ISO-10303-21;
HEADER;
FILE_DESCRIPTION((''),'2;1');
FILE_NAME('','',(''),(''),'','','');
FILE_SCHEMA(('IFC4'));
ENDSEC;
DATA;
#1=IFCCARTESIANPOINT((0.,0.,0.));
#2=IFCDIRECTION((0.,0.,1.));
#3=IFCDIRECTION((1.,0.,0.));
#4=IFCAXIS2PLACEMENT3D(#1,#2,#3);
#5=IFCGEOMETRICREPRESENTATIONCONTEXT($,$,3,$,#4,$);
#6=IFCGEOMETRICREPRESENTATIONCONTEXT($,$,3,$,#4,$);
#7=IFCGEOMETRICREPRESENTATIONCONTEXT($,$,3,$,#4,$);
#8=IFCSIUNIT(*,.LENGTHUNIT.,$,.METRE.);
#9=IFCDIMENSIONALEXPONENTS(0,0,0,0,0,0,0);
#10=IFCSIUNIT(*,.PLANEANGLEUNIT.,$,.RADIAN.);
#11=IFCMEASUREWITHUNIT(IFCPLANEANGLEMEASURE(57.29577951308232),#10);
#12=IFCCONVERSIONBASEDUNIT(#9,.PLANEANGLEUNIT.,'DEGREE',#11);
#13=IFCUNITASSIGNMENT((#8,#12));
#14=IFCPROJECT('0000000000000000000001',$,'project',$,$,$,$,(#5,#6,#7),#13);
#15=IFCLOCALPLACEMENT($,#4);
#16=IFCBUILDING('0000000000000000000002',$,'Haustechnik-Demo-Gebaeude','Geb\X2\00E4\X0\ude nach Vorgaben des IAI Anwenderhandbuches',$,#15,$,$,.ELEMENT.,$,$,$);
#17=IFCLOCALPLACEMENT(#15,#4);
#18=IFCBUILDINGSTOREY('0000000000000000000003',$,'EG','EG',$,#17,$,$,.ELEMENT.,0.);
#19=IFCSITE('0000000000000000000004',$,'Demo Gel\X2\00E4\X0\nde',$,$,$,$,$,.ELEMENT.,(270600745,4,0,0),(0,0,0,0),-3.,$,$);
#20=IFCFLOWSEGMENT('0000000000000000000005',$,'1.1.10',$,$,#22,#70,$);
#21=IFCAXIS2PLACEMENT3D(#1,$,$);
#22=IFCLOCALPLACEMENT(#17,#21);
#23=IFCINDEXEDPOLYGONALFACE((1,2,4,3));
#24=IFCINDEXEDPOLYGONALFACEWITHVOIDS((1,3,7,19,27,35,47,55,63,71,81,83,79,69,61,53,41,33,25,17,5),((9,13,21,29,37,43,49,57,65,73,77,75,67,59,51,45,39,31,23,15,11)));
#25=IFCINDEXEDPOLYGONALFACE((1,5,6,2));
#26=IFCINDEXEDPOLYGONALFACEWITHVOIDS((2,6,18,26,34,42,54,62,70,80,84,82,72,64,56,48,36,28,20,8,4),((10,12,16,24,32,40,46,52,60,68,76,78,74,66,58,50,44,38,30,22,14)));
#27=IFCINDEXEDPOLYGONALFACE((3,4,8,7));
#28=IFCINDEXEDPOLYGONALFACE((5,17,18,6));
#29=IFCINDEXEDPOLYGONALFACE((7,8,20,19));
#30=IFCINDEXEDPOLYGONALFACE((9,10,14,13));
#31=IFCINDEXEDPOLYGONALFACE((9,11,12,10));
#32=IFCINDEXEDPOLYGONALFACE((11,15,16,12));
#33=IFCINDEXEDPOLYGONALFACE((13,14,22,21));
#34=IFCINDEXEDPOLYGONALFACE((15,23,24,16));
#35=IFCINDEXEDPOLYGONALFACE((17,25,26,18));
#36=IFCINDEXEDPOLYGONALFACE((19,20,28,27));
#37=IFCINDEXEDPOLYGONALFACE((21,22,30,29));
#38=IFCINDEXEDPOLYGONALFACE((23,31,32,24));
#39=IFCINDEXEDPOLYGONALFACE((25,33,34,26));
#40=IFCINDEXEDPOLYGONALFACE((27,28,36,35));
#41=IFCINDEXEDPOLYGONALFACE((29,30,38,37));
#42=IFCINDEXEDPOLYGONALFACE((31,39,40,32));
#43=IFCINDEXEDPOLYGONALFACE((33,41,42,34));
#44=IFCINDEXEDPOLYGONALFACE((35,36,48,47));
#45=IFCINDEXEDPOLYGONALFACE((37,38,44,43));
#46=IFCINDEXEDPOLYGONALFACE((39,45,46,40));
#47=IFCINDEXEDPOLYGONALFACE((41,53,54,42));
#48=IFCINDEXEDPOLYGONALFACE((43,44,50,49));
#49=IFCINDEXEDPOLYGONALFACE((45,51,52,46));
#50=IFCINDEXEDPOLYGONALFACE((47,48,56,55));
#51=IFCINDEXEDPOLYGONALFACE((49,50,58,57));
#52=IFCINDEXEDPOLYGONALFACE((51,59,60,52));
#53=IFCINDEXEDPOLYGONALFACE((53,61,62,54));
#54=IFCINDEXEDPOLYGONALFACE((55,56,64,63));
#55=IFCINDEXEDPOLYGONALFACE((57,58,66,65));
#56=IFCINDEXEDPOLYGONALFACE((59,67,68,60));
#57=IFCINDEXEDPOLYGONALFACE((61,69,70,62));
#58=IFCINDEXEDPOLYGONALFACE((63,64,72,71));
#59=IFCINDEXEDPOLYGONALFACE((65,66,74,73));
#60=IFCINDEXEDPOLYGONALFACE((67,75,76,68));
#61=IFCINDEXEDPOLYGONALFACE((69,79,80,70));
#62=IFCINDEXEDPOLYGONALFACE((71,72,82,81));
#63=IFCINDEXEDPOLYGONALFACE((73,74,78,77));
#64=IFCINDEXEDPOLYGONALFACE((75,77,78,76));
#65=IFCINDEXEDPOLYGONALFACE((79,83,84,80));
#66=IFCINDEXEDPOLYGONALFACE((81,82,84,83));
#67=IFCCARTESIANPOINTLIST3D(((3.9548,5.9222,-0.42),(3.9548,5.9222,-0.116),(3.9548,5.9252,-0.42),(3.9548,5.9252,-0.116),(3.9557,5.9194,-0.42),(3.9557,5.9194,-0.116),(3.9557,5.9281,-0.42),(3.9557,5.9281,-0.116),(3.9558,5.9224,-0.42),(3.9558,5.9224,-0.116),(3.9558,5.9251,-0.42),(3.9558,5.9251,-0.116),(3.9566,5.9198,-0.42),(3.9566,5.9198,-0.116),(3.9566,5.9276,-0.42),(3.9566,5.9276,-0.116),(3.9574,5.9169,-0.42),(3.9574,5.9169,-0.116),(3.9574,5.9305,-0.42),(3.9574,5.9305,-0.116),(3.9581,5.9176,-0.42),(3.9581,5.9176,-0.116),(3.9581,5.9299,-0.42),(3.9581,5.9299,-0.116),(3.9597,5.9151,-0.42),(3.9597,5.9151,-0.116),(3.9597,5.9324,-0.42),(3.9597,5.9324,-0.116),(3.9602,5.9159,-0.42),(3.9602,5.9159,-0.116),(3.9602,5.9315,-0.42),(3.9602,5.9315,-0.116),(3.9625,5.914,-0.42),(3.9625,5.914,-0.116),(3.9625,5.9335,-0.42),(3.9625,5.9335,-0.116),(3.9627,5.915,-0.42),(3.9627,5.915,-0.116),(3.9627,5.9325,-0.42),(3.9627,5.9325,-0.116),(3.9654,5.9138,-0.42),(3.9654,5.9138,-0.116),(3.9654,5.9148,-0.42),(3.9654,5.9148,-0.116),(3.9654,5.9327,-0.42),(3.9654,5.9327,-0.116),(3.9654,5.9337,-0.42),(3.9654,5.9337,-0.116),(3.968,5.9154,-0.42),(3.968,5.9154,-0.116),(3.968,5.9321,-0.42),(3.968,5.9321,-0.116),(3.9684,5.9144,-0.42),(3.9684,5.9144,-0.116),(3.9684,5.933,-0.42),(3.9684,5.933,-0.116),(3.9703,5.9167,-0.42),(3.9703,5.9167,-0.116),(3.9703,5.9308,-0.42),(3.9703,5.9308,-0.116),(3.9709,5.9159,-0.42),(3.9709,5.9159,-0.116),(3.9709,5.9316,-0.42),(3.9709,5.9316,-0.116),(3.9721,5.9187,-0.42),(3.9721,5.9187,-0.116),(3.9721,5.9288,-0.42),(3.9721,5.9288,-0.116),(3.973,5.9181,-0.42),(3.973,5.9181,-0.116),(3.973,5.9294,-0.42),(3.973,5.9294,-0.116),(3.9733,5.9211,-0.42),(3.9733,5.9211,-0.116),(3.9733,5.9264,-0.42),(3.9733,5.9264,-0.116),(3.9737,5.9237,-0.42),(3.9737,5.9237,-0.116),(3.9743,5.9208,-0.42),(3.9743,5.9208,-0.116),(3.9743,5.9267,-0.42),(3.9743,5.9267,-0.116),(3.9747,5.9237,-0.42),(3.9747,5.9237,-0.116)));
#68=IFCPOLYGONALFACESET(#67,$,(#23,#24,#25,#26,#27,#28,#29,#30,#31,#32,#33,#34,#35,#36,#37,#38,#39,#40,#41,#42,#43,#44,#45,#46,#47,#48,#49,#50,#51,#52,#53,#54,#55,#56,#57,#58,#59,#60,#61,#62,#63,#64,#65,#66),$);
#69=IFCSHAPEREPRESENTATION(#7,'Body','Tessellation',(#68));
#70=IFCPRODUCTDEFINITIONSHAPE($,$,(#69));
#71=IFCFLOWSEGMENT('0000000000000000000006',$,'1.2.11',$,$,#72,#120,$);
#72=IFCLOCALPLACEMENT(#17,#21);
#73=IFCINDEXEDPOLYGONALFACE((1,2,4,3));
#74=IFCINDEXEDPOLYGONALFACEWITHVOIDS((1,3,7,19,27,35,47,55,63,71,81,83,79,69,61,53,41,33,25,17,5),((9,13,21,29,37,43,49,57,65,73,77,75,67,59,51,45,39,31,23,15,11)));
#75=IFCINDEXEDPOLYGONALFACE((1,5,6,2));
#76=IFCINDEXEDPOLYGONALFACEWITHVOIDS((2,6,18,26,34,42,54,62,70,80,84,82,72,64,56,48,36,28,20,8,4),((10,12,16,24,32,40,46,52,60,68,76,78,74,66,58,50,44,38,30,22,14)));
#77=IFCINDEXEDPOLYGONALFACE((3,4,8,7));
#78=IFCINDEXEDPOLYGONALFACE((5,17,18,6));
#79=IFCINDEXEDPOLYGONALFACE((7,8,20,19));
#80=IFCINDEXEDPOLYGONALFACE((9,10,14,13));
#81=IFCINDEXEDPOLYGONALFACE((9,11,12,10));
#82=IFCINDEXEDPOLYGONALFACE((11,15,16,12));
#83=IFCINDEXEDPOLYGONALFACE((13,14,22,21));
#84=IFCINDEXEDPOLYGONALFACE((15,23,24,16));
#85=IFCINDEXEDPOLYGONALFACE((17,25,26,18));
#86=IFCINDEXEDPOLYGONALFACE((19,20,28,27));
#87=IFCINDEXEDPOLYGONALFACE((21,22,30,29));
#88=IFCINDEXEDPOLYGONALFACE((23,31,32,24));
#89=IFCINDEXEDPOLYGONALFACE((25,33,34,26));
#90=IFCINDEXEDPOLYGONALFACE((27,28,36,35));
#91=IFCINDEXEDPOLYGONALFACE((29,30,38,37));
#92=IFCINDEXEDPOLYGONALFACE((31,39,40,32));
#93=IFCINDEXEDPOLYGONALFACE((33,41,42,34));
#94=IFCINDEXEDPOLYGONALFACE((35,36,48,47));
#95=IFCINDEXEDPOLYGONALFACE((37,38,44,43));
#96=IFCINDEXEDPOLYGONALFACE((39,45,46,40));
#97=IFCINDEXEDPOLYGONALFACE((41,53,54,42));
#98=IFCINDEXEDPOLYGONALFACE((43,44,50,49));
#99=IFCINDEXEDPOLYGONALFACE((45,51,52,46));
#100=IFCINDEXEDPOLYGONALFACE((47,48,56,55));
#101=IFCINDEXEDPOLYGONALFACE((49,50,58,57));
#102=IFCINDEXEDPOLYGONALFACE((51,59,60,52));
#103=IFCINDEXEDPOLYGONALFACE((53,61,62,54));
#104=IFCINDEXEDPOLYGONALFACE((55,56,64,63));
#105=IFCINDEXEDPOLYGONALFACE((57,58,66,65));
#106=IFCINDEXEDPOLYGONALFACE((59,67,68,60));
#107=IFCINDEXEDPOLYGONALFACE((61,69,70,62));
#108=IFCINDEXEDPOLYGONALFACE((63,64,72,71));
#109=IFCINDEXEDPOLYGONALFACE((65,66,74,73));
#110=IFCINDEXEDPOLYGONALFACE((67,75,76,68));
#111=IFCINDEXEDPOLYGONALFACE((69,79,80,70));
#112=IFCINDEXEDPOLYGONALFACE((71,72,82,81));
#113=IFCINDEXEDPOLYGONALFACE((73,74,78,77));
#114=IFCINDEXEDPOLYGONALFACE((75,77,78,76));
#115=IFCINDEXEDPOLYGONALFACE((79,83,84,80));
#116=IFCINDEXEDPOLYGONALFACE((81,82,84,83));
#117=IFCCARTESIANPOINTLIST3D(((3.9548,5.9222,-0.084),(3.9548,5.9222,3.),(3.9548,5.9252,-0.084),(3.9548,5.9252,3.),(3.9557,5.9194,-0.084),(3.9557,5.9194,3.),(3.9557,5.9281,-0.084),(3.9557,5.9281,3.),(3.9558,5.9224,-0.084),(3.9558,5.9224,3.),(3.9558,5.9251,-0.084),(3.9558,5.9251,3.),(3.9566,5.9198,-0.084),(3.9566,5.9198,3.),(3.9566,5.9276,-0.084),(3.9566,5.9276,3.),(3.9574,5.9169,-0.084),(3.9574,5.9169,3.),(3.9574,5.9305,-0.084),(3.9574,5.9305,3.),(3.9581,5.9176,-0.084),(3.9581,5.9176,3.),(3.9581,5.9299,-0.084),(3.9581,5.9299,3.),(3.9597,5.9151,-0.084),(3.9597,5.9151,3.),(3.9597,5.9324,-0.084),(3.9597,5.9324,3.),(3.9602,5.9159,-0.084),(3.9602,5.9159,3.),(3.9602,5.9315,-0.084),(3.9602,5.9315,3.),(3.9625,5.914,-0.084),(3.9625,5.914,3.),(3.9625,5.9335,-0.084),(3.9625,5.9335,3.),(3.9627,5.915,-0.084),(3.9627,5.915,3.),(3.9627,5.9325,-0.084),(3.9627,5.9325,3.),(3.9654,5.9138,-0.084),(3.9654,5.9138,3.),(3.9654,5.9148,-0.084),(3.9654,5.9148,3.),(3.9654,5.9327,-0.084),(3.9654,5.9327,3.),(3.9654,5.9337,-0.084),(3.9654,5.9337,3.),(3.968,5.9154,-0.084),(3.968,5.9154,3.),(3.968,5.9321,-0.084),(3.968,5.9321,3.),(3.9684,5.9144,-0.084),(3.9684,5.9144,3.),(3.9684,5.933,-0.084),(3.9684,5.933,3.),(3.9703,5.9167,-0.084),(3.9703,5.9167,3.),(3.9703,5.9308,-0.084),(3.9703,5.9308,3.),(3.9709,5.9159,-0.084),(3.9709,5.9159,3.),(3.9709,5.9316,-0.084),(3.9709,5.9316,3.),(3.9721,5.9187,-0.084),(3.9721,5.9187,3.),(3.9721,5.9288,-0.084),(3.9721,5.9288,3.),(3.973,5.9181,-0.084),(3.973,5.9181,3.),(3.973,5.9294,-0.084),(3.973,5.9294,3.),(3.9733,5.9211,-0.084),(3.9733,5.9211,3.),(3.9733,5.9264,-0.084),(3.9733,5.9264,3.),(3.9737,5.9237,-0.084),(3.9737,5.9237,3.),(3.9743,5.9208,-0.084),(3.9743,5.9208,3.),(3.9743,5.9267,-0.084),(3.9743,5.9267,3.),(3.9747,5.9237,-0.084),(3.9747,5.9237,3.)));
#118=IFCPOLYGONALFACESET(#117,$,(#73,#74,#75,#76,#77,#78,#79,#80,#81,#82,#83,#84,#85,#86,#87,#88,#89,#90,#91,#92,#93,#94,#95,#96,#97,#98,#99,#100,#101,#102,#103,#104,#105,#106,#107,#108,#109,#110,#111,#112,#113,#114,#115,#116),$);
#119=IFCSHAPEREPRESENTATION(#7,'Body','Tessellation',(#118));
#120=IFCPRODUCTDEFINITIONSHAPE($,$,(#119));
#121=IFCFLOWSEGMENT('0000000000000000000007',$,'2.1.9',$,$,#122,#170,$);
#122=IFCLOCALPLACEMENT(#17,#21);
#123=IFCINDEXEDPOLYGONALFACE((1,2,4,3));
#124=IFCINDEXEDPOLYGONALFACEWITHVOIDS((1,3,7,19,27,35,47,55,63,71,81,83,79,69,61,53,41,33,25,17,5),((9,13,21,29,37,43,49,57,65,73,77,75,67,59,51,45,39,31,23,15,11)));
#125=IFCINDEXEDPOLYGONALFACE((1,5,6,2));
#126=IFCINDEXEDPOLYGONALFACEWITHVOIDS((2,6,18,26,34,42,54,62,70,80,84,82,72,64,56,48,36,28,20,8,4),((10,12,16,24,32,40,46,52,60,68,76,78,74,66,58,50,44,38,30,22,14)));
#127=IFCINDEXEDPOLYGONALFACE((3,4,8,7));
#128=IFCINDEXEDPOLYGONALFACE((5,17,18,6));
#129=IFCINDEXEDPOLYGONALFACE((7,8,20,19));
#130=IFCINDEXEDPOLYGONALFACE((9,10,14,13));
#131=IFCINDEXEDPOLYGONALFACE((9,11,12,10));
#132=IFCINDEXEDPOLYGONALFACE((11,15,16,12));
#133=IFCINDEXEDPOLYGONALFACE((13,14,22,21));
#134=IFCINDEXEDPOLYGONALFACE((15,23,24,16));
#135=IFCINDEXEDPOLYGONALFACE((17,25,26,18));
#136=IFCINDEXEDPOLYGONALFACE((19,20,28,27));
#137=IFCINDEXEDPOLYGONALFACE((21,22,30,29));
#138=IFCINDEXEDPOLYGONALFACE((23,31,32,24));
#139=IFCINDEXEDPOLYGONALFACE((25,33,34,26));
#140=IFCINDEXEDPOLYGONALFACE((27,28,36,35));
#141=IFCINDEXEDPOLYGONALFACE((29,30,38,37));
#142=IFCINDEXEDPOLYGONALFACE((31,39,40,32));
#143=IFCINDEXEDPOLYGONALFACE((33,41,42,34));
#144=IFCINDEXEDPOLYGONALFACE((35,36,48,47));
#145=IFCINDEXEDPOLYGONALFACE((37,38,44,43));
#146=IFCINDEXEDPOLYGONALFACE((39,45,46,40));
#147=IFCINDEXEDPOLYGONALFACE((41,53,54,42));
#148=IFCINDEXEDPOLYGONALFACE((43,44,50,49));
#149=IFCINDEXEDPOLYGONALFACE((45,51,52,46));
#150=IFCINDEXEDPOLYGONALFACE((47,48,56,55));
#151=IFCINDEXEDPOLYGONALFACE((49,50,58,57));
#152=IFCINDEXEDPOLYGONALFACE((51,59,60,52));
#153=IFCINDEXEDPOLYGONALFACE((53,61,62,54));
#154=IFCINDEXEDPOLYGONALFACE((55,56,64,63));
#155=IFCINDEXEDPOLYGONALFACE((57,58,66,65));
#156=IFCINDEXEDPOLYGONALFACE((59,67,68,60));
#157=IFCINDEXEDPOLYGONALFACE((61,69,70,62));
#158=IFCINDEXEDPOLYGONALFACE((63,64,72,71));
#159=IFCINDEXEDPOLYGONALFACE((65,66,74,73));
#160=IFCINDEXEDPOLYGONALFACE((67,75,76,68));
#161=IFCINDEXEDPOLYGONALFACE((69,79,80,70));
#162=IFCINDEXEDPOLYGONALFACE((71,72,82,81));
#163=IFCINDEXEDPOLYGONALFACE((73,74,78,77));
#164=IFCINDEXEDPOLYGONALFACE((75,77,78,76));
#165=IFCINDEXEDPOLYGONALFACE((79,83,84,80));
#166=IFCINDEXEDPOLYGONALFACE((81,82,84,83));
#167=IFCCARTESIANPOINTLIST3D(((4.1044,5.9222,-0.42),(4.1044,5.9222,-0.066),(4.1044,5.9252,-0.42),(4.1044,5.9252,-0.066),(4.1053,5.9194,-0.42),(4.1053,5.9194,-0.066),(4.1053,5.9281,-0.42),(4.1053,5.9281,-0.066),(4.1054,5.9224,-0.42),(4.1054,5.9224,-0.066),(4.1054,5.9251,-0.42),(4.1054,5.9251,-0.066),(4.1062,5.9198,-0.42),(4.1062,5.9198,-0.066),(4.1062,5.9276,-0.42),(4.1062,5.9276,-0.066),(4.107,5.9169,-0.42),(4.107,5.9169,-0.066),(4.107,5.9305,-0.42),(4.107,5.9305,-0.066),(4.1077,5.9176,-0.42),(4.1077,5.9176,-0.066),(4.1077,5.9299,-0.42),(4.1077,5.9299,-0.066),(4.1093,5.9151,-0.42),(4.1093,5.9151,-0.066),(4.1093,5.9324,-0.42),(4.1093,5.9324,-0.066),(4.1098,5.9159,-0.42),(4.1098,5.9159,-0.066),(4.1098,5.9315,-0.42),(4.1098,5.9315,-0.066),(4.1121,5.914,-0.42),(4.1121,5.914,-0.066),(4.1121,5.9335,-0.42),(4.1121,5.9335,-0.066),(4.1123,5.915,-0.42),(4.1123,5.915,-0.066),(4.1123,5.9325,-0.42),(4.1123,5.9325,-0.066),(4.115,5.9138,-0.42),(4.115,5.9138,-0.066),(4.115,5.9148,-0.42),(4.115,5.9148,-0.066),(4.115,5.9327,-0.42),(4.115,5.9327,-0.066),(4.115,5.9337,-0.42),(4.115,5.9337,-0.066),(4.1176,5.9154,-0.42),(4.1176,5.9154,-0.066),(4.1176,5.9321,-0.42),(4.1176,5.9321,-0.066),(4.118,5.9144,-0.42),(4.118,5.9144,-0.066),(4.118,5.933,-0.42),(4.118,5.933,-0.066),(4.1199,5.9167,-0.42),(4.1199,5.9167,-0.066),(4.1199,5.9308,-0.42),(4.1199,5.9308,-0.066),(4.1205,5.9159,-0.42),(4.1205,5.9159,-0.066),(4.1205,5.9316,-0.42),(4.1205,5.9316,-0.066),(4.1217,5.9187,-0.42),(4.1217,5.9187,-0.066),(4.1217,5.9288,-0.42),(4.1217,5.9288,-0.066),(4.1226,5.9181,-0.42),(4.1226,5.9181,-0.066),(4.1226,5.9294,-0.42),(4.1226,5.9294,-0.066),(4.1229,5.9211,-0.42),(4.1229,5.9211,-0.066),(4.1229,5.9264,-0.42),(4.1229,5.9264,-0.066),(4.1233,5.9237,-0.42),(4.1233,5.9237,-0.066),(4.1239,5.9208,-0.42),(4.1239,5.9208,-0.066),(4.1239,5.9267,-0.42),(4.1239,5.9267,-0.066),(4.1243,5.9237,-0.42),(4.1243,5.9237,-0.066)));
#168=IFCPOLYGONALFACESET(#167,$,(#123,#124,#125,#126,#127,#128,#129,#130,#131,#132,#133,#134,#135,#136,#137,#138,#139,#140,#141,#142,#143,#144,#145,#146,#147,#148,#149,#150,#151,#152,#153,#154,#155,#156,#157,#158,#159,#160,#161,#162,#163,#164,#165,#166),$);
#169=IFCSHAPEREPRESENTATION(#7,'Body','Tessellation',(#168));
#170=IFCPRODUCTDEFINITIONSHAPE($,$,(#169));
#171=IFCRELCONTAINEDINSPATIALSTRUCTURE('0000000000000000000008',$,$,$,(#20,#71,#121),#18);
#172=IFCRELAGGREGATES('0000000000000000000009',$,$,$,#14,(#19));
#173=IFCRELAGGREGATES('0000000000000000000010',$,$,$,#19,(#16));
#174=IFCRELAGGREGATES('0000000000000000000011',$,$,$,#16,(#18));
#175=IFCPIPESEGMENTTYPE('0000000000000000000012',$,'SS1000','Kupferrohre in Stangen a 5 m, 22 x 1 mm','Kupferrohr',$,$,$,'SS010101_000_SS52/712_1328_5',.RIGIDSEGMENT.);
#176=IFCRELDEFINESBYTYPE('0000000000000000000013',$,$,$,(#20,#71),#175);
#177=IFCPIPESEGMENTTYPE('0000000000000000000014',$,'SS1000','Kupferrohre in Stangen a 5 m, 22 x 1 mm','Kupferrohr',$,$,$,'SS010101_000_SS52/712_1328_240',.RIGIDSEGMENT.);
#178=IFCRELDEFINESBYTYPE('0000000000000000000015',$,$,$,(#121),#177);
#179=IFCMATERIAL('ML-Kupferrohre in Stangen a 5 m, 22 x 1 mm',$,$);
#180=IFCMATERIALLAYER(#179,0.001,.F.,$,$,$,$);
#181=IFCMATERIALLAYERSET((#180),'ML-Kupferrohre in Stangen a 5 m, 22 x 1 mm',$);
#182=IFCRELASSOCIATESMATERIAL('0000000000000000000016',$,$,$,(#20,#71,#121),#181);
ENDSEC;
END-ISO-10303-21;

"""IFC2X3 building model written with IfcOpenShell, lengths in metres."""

from ifc_helpers import new_model, entity, si_unit, converted_unit, frame, origin_with_axes, origin_2d_with_axis, place, context, project, spatial, hollow_circle, extrude, material, layer, layer_set, layer_usage, type_object, element, save


model = new_model("IFC2X3")

# Units and contexts
context_of_model_1 = context(None, 3, world=origin_with_axes())
context_of_model_2 = context(None, 3, world=origin_with_axes())
context_of_model_3 = context(None, 3, world=origin_with_axes())
ifc_project = project(units=[si_unit("LENGTHUNIT", "METRE"), converted_unit("PLANEANGLEUNIT", "DEGREE", entity("IfcPlaneAngleMeasure", 57.29577951308232), si_unit("PLANEANGLEUNIT", "RADIAN"), dimensions=[0, 0, 0, 0, 0, 0, 0])], contexts=[context_of_model_1, context_of_model_2, context_of_model_3])

# Site, building, storey
site = spatial("IfcSite", under=ifc_project, Name="Demo Gelände", CompositionType="ELEMENT", RefLatitude=(270600745, 4, 0, 0), RefLongitude=(0, 0, 0, 0), RefElevation=-3.0)
building_placement = place(None, origin_with_axes())
building = spatial("IfcBuilding", under=site, at=building_placement, Name="Haustechnik-Demo-Gebaeude", Description="Gebäude nach Vorgaben des IAI Anwenderhandbuches", CompositionType="ELEMENT")
storey_placement = place(building_placement, origin_with_axes())
storey = spatial("IfcBuildingStorey", under=building, at=storey_placement, Name="EG", Description="EG", CompositionType="ELEMENT", Elevation=0.0)

# Flow segments
ifc_material_1 = material(Name="ML-Kupferrohre in Stangen a 5 m, 22 x 1 mm")
ifc_layer_1 = layer(ifc_material_1, 0.001, ventilated=False)
ifc_layer_set_1 = layer_set([ifc_layer_1], Name="ML-Kupferrohre in Stangen a 5 m, 22 x 1 mm")
ifc_layer_usage_1 = layer_usage(ifc_layer_set_1, "AXIS2", "POSITIVE", 0.0)
pipe_segment_type_1 = type_object("IfcPipeSegmentType", Name="SS1000", Description="Kupferrohre in Stangen a 5 m, 22 x 1 mm", ApplicableOccurrence="Kupferrohr", ElementType="SS010101_000_SS52/712_1328_5", PredefinedType="RIGIDSEGMENT")
flow_segment_1_placement = place(storey_placement, frame((3.9647, 5.9237, -0.42), z_axis=(0.0, 0.0, 1.0), x_axis=(1.0, 0.0, 0.0)))
element("IfcFlowSegment", 1, at=flow_segment_1_placement, inside=storey, type_object=pipe_segment_type_1, material=ifc_layer_usage_1, Name="1.1.10", context=context_of_model_3, shape_type="SweptSolid", body=[
    extrude(hollow_circle(Radius=0.01, WallThickness=0.001, at=origin_2d_with_axis()), origin_with_axes(), (0.0, 0.0, 1.0), 0.304),
])
flow_segment_2_placement = place(storey_placement, frame((3.9647, 5.9237, -0.084), z_axis=(0.0, 0.0, 1.0), x_axis=(1.0, 0.0, 0.0)))
element("IfcFlowSegment", 2, at=flow_segment_2_placement, inside=storey, type_object=pipe_segment_type_1, material=ifc_layer_usage_1, Name="1.2.11", context=context_of_model_3, shape_type="SweptSolid", body=[
    extrude(hollow_circle(Radius=0.01, WallThickness=0.001, at=origin_2d_with_axis()), origin_with_axes(), (0.0, 0.0, 1.0), 3.084),
])
pipe_segment_type_2 = type_object("IfcPipeSegmentType", Name="SS1000", Description="Kupferrohre in Stangen a 5 m, 22 x 1 mm", ApplicableOccurrence="Kupferrohr", ElementType="SS010101_000_SS52/712_1328_240", PredefinedType="RIGIDSEGMENT")
flow_segment_3_placement = place(storey_placement, frame((4.1143, 5.9237, -0.42), z_axis=(0.0, 0.0, 1.0), x_axis=(1.0, 0.0, 0.0)))
element("IfcFlowSegment", 3, at=flow_segment_3_placement, inside=storey, type_object=pipe_segment_type_2, material=ifc_layer_usage_1, Name="2.1.9", context=context_of_model_3, shape_type="SweptSolid", body=[
    extrude(hollow_circle(Radius=0.01, WallThickness=0.001, at=origin_2d_with_axis()), origin_with_axes(), (0.0, 0.0, 1.0), 0.354),
])

save(model, "model.ifc")
